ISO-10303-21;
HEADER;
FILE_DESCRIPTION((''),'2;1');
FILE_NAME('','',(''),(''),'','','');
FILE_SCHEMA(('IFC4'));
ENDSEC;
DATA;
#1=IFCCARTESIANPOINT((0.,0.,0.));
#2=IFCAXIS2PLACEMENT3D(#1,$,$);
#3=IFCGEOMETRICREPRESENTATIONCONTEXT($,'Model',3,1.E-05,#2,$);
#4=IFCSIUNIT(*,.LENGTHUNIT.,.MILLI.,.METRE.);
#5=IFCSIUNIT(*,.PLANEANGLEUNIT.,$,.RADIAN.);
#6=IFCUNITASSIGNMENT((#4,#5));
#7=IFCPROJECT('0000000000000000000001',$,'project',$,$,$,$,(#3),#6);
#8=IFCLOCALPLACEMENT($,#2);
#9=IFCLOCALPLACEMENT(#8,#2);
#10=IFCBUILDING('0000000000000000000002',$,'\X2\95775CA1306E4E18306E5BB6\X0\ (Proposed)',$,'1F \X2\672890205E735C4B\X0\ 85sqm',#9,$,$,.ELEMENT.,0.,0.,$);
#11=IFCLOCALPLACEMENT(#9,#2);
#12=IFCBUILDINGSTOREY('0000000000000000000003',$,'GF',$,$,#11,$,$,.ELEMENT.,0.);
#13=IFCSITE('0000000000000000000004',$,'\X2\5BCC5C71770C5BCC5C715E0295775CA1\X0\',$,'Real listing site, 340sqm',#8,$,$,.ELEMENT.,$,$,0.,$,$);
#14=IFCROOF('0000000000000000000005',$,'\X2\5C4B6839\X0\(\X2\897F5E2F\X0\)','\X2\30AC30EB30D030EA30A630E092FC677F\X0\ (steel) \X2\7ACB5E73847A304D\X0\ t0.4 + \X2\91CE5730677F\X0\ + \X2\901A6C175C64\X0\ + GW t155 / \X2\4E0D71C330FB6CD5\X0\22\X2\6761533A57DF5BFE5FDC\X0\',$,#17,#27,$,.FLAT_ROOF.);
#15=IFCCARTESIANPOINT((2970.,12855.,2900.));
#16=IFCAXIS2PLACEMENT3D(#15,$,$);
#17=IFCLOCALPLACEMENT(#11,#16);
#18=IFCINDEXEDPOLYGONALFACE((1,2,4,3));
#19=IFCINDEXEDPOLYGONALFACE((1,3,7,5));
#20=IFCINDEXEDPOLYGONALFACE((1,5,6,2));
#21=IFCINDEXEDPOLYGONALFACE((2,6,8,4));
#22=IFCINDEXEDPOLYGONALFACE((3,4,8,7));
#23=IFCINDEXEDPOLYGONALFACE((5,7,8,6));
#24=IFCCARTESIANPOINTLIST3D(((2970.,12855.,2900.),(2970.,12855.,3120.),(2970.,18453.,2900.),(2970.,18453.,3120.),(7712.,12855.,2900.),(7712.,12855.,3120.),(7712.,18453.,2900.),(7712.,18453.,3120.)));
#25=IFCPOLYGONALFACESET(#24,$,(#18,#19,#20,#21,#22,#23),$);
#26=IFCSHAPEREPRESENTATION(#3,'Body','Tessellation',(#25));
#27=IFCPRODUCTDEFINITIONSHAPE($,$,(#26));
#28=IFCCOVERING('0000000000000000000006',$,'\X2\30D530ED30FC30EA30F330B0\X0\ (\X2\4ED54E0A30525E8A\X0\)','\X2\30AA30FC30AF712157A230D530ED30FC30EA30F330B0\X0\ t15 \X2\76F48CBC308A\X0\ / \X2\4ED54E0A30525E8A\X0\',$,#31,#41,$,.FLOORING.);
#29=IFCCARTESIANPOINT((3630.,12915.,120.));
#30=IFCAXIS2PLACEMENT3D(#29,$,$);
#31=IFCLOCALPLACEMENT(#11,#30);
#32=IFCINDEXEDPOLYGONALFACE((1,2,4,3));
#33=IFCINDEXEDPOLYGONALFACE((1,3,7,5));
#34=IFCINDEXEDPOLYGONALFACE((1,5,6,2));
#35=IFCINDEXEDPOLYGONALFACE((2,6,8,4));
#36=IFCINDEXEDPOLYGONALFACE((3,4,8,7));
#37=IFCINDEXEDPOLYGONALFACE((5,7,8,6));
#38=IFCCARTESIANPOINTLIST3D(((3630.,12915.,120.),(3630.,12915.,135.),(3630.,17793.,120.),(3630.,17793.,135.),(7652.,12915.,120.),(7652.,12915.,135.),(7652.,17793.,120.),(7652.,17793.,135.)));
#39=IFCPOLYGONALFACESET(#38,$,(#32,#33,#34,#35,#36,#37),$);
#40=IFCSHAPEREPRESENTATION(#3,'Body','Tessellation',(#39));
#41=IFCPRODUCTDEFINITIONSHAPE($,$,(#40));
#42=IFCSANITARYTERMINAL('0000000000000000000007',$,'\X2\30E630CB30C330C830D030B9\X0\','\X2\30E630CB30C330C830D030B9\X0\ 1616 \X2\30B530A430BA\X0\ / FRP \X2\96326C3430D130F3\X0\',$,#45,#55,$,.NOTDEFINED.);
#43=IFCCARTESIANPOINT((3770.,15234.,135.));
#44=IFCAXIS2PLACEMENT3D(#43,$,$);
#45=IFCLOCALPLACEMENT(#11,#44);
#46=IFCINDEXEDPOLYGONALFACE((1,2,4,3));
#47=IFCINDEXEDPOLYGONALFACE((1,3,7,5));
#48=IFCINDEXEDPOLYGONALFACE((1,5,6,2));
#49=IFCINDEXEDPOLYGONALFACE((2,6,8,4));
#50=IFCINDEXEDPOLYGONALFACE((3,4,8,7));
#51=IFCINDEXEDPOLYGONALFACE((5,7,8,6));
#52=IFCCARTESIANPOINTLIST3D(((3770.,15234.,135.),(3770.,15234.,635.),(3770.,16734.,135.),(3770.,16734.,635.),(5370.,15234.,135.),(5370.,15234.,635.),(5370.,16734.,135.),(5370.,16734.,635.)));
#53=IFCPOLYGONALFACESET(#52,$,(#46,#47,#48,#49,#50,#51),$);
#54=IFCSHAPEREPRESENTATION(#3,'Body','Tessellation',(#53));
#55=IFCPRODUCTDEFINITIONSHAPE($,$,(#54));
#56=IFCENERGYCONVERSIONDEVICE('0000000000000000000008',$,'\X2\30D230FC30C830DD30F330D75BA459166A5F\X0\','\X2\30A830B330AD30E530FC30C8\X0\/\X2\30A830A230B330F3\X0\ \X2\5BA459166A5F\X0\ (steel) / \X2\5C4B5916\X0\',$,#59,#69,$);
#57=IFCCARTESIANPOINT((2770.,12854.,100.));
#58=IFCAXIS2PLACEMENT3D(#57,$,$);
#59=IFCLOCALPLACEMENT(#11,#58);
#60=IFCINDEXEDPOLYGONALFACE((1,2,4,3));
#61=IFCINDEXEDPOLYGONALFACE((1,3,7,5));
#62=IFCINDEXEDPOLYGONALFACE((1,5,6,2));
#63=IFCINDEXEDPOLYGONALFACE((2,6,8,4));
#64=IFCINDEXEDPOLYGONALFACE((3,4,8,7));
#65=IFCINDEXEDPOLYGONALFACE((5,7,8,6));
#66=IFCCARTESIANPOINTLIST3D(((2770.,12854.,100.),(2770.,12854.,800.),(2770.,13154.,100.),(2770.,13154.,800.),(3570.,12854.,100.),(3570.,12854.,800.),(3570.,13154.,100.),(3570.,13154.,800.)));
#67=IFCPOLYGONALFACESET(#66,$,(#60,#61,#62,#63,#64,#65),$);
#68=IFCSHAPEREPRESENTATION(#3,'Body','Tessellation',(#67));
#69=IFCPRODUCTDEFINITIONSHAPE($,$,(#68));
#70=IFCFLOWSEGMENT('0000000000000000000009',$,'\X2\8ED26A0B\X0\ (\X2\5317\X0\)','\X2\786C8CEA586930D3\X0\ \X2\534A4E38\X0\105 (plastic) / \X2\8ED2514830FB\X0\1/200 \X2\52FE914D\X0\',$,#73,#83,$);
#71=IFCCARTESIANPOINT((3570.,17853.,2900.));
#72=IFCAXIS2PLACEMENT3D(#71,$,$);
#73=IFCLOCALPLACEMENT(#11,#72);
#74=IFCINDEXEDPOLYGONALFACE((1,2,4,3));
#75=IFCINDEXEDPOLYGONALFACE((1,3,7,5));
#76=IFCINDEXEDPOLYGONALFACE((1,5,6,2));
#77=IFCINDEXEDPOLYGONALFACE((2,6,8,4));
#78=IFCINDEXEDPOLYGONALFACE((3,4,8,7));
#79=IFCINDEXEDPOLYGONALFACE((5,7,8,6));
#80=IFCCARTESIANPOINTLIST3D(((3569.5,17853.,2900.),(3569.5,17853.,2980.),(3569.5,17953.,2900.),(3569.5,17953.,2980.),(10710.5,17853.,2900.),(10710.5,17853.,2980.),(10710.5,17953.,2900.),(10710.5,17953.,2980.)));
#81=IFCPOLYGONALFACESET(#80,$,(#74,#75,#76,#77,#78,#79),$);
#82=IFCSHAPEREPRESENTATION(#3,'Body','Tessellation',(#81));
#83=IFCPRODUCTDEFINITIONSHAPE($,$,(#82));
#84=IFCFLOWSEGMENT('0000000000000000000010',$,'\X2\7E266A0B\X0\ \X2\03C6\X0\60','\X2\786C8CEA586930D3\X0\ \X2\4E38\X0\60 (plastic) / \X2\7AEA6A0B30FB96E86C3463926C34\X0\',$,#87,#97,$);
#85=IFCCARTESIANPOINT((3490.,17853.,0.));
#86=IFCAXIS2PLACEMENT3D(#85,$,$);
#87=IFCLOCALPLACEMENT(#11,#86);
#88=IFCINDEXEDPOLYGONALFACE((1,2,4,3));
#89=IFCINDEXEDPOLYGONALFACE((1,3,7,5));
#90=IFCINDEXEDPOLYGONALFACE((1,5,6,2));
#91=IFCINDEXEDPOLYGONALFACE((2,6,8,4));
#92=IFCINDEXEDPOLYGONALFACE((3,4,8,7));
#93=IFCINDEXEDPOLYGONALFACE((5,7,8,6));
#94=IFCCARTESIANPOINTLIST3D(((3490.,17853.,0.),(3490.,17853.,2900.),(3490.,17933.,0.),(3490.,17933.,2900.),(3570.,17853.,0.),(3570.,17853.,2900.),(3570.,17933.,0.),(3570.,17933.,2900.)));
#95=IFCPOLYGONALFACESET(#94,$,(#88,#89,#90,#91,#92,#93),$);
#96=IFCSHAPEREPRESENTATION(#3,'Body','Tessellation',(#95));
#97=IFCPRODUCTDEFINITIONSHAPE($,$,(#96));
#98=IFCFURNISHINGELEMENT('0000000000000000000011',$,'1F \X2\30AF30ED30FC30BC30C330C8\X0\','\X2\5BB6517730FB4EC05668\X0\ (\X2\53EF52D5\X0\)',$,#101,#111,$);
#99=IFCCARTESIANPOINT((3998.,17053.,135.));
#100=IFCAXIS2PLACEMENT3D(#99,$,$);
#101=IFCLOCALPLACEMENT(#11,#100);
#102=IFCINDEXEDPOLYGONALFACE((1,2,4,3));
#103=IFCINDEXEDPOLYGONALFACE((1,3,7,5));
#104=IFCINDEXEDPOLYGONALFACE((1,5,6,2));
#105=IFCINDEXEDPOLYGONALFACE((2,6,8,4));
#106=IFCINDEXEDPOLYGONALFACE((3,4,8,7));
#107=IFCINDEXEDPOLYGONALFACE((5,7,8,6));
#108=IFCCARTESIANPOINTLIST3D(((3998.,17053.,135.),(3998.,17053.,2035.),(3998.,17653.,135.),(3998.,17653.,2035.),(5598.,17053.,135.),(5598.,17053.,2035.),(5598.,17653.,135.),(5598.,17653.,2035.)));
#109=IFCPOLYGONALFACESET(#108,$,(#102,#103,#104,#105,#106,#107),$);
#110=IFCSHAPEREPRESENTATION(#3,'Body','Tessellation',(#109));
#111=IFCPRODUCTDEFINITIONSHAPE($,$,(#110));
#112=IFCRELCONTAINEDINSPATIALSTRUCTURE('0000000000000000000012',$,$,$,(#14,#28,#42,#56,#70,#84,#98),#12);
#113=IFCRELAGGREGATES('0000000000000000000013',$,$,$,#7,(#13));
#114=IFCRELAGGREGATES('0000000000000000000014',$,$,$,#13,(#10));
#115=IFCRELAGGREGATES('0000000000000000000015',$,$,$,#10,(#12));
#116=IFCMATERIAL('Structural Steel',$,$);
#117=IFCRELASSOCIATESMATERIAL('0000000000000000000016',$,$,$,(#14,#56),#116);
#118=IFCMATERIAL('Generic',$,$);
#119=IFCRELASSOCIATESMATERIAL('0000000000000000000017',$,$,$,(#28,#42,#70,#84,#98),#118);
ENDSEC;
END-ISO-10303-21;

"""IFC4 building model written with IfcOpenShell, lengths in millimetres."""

from ifc_helpers import new_model, si_unit, frame, frame_2d, origin, place, context, project, spatial, rectangle, extrude, material, element, save


model = new_model("IFC4")

# Units and contexts
model_context = context("Model", 3, precision=1e-05, world=origin())
ifc_project = project(units=[si_unit("LENGTHUNIT", "METRE", prefix="MILLI"), si_unit("PLANEANGLEUNIT", "RADIAN")], contexts=[model_context])

# Site, building, storey
site_placement = place(None, origin())
site = spatial("IfcSite", under=ifc_project, at=site_placement, Name="富山県富山市長岡", ObjectType="Real listing site, 340sqm", CompositionType="ELEMENT", RefElevation=0.0)
building_placement = place(site_placement, origin())
building = spatial("IfcBuilding", under=site, at=building_placement, Name="長岡の丘の家 (Proposed)", ObjectType="1F 木造平屋 85sqm", CompositionType="ELEMENT", ElevationOfRefHeight=0.0, ElevationOfTerrain=0.0)
storey_placement = place(building_placement, origin())
storey = spatial("IfcBuildingStorey", under=building, at=storey_placement, Name="GF", CompositionType="ELEMENT", Elevation=0.0)

# Roof
ifc_material_1 = material(Name="Structural Steel")
roof_placement = place(storey_placement, frame((2970.0, 12855.0, 2900.0)))
element("IfcRoof", 1, at=roof_placement, inside=storey, material=ifc_material_1, Name="屋根(西帯)", Description="ガルバリウム鋼板 (steel) 立平葺き t0.4 + 野地板 + 通気層 + GW t155 / 不燃・法22条区域対応", PredefinedType="FLAT_ROOF", context=model_context, shape_type="SweptSolid", body=[
    extrude(rectangle(XDim=4742.0, YDim=5598.0, at=frame_2d((2371.0, 2799.0))), frame((2970.0, 12855.0, 2900.0)), (0.0, 0.0, 1.0), 220.0),
])

# Covering
ifc_material_2 = material(Name="Generic")
covering_placement = place(storey_placement, frame((3630.0, 12915.0, 120.0)))
element("IfcCovering", 2, at=covering_placement, inside=storey, material=ifc_material_2, Name="フローリング (仕上げ床)", Description="オーク無垢フローリング t15 直貼り / 仕上げ床", PredefinedType="FLOORING", context=model_context, shape_type="SweptSolid", body=[
    extrude(rectangle(XDim=4022.0, YDim=4878.0, at=frame_2d((2011.0, 2439.0))), frame((3630.0, 12915.0, 120.0)), (0.0, 0.0, 1.0), 15.0),
])

# Sanitary terminal
sanitary_terminal_placement = place(storey_placement, frame((3770.0, 15234.0, 135.0)))
element("IfcSanitaryTerminal", 3, at=sanitary_terminal_placement, inside=storey, material=ifc_material_2, Name="ユニットバス", Description="ユニットバス 1616 サイズ / FRP 防水パン", PredefinedType="NOTDEFINED", context=model_context, shape_type="SweptSolid", body=[
    extrude(rectangle(XDim=1600.0, YDim=1500.0, at=frame_2d((800.0, 750.0))), frame((3770.0, 15234.0, 135.0)), (0.0, 0.0, 1.0), 500.0),
])

# Energy conversion device
energy_conversion_device_placement = place(storey_placement, frame((2770.0, 12854.0, 100.0)))
element("IfcEnergyConversionDevice", 4, at=energy_conversion_device_placement, inside=storey, material=ifc_material_1, Name="ヒートポンプ室外機", Description="エコキュート/エアコン 室外機 (steel) / 屋外", context=model_context, shape_type="SweptSolid", body=[
    extrude(rectangle(XDim=800.0, YDim=300.0, at=frame_2d((400.0, 150.0))), frame((2770.0, 12854.0, 100.0)), (0.0, 0.0, 1.0), 700.0),
])

# Flow segments
flow_segment_1_placement = place(storey_placement, frame((3570.0, 17853.0, 2900.0)))
element("IfcFlowSegment", 5, at=flow_segment_1_placement, inside=storey, material=ifc_material_2, Name="軒樋 (北)", Description="硬質塩ビ 半丸105 (plastic) / 軒先・1/200 勾配", context=model_context, shape_type="SweptSolid", body=[
    extrude(rectangle(XDim=7141.0, YDim=100.0, at=frame_2d((3570.0, 50.0))), frame((3570.0, 17853.0, 2900.0)), (0.0, 0.0, 1.0), 80.0),
])
flow_segment_2_placement = place(storey_placement, frame((3490.0, 17853.0, 0.0)))
element("IfcFlowSegment", 6, at=flow_segment_2_placement, inside=storey, material=ifc_material_2, Name="縦樋 φ60", Description="硬質塩ビ 丸60 (plastic) / 竪樋・雨水排水", context=model_context, shape_type="SweptSolid", body=[
    extrude(rectangle(XDim=80.0, YDim=80.0, at=frame_2d((40.0, 40.0))), frame((3490.0, 17853.0, 0.0)), (0.0, 0.0, 1.0), 2900.0),
])

# Furnishing element
furnishing_placement = place(storey_placement, frame((3998.0, 17053.0, 135.0)))
element("IfcFurnishingElement", 7, at=furnishing_placement, inside=storey, material=ifc_material_2, Name="1F クローゼット", Description="家具・什器 (可動)", context=model_context, shape_type="SweptSolid", body=[
    extrude(rectangle(XDim=1600.0, YDim=600.0, at=frame_2d((800.0, 300.0))), frame((3998.0, 17053.0, 135.0)), (0.0, 0.0, 1.0), 1900.0),
])

save(model, "model.ifc")
